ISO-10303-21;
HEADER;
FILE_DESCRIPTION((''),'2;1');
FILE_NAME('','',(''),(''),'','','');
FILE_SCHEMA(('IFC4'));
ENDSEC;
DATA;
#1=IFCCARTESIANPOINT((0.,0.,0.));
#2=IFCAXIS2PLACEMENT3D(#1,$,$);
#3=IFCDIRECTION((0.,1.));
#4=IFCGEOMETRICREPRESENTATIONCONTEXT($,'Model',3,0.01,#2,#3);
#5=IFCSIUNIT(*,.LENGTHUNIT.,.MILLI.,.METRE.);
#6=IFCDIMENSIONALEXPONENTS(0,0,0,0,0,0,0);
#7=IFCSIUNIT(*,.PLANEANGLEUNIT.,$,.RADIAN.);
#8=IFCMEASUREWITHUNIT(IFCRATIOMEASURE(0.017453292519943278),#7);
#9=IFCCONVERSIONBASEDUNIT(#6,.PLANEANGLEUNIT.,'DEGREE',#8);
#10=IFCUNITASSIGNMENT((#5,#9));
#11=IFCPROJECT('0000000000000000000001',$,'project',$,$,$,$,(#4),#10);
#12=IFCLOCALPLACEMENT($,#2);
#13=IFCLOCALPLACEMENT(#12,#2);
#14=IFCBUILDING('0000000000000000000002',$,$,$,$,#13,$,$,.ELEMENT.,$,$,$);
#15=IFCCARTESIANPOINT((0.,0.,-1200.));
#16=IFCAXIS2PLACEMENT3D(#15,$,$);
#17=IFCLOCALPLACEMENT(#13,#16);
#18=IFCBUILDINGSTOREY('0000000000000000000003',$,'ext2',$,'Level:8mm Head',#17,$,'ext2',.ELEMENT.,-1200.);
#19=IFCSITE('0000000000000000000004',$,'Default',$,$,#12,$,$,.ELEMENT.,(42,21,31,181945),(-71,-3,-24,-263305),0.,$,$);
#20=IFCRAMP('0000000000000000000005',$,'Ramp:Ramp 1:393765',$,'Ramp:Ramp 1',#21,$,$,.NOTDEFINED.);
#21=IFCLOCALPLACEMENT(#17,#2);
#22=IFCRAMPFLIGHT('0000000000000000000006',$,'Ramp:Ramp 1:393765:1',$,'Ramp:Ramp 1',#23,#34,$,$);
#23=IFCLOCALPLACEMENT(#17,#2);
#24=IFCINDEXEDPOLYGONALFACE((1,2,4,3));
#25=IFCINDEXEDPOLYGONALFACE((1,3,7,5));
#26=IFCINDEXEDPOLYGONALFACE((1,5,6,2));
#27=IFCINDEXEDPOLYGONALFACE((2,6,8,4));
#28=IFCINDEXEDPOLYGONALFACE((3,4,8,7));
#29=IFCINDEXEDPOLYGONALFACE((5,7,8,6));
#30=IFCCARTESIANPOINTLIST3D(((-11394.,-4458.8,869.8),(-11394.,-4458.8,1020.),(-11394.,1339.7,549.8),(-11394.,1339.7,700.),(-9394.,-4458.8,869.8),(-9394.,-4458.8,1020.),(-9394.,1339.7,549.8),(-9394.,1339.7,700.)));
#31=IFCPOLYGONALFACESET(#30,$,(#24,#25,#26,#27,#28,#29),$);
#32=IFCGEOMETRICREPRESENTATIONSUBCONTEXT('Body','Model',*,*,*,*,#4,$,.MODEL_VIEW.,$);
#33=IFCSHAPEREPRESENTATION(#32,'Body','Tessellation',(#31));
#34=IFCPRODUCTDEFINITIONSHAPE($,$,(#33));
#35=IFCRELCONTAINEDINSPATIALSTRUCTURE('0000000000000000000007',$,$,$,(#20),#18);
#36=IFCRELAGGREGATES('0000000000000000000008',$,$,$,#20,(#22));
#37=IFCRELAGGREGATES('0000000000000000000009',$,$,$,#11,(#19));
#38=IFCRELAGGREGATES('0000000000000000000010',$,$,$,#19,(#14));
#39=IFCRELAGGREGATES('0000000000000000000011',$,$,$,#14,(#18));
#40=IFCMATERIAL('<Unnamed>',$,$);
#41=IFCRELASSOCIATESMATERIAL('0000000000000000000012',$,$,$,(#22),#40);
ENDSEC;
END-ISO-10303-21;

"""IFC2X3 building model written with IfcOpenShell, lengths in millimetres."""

from ifc_helpers import new_model, entity, si_unit, converted_unit, direction, frame, origin, place, context, subcontext, project, spatial, polyline, outline, extrude, material, element, aggregate, save


model = new_model("IFC2X3")

# Units and contexts
model_context = context("Model", 3, precision=0.01, world=origin(), true_north=direction((0.0, 1.0)))
body_context = subcontext(model_context, "Body", "Model", "MODEL_VIEW")
ifc_project = project(units=[si_unit("LENGTHUNIT", "METRE", prefix="MILLI"), converted_unit("PLANEANGLEUNIT", "DEGREE", entity("IfcRatioMeasure", 0.017453292519943278), si_unit("PLANEANGLEUNIT", "RADIAN"), dimensions=[0, 0, 0, 0, 0, 0, 0])], contexts=[model_context])

# Site, building, storey
site_placement = place(None, origin())
site = spatial("IfcSite", under=ifc_project, at=site_placement, Name="Default", CompositionType="ELEMENT", RefLatitude=(42, 21, 31, 181945), RefLongitude=(-71, -3, -24, -263305), RefElevation=0.0)
building_placement = place(site_placement, origin())
building = spatial("IfcBuilding", under=site, at=building_placement, CompositionType="ELEMENT")
storey_placement = place(building_placement, frame((0.0, 0.0, -1200.0)))
storey = spatial("IfcBuildingStorey", under=building, at=storey_placement, Name="ext2", ObjectType="Level:8mm Head", LongName="ext2", CompositionType="ELEMENT", Elevation=-1200.0)

# Ramp, ramp flight
ramp_placement = place(storey_placement, origin())
ramp = element("IfcRamp", 1, at=ramp_placement, inside=storey, Name="Ramp:Ramp 1:393765", ObjectType="Ramp:Ramp 1", ShapeType="NOTDEFINED")
ifc_material = material(Name="<Unnamed>")
ramp_flight_placement = place(ramp_placement, origin())
ramp_flight = element("IfcRampFlight", 2, at=ramp_flight_placement, material=ifc_material, Name="Ramp:Ramp 1:393765:1", ObjectType="Ramp:Ramp 1", context=body_context, shape_type="SweptSolid", body=[
    extrude(outline(polyline([(-235.1, -2899.2), (-84.9, -2899.2), (235.1, 2899.2), (84.9, 2899.2), (-235.1, -2899.2)])), frame((-11394.0, -1559.5, 784.9), z_axis=(1.0, 0.0, 0.0), x_axis=(0.0, 0.0, -1.0)), (0.0, 0.0, 1.0), 2000.0),
])
aggregate(ramp, [ramp_flight])

save(model, "model.ifc")
